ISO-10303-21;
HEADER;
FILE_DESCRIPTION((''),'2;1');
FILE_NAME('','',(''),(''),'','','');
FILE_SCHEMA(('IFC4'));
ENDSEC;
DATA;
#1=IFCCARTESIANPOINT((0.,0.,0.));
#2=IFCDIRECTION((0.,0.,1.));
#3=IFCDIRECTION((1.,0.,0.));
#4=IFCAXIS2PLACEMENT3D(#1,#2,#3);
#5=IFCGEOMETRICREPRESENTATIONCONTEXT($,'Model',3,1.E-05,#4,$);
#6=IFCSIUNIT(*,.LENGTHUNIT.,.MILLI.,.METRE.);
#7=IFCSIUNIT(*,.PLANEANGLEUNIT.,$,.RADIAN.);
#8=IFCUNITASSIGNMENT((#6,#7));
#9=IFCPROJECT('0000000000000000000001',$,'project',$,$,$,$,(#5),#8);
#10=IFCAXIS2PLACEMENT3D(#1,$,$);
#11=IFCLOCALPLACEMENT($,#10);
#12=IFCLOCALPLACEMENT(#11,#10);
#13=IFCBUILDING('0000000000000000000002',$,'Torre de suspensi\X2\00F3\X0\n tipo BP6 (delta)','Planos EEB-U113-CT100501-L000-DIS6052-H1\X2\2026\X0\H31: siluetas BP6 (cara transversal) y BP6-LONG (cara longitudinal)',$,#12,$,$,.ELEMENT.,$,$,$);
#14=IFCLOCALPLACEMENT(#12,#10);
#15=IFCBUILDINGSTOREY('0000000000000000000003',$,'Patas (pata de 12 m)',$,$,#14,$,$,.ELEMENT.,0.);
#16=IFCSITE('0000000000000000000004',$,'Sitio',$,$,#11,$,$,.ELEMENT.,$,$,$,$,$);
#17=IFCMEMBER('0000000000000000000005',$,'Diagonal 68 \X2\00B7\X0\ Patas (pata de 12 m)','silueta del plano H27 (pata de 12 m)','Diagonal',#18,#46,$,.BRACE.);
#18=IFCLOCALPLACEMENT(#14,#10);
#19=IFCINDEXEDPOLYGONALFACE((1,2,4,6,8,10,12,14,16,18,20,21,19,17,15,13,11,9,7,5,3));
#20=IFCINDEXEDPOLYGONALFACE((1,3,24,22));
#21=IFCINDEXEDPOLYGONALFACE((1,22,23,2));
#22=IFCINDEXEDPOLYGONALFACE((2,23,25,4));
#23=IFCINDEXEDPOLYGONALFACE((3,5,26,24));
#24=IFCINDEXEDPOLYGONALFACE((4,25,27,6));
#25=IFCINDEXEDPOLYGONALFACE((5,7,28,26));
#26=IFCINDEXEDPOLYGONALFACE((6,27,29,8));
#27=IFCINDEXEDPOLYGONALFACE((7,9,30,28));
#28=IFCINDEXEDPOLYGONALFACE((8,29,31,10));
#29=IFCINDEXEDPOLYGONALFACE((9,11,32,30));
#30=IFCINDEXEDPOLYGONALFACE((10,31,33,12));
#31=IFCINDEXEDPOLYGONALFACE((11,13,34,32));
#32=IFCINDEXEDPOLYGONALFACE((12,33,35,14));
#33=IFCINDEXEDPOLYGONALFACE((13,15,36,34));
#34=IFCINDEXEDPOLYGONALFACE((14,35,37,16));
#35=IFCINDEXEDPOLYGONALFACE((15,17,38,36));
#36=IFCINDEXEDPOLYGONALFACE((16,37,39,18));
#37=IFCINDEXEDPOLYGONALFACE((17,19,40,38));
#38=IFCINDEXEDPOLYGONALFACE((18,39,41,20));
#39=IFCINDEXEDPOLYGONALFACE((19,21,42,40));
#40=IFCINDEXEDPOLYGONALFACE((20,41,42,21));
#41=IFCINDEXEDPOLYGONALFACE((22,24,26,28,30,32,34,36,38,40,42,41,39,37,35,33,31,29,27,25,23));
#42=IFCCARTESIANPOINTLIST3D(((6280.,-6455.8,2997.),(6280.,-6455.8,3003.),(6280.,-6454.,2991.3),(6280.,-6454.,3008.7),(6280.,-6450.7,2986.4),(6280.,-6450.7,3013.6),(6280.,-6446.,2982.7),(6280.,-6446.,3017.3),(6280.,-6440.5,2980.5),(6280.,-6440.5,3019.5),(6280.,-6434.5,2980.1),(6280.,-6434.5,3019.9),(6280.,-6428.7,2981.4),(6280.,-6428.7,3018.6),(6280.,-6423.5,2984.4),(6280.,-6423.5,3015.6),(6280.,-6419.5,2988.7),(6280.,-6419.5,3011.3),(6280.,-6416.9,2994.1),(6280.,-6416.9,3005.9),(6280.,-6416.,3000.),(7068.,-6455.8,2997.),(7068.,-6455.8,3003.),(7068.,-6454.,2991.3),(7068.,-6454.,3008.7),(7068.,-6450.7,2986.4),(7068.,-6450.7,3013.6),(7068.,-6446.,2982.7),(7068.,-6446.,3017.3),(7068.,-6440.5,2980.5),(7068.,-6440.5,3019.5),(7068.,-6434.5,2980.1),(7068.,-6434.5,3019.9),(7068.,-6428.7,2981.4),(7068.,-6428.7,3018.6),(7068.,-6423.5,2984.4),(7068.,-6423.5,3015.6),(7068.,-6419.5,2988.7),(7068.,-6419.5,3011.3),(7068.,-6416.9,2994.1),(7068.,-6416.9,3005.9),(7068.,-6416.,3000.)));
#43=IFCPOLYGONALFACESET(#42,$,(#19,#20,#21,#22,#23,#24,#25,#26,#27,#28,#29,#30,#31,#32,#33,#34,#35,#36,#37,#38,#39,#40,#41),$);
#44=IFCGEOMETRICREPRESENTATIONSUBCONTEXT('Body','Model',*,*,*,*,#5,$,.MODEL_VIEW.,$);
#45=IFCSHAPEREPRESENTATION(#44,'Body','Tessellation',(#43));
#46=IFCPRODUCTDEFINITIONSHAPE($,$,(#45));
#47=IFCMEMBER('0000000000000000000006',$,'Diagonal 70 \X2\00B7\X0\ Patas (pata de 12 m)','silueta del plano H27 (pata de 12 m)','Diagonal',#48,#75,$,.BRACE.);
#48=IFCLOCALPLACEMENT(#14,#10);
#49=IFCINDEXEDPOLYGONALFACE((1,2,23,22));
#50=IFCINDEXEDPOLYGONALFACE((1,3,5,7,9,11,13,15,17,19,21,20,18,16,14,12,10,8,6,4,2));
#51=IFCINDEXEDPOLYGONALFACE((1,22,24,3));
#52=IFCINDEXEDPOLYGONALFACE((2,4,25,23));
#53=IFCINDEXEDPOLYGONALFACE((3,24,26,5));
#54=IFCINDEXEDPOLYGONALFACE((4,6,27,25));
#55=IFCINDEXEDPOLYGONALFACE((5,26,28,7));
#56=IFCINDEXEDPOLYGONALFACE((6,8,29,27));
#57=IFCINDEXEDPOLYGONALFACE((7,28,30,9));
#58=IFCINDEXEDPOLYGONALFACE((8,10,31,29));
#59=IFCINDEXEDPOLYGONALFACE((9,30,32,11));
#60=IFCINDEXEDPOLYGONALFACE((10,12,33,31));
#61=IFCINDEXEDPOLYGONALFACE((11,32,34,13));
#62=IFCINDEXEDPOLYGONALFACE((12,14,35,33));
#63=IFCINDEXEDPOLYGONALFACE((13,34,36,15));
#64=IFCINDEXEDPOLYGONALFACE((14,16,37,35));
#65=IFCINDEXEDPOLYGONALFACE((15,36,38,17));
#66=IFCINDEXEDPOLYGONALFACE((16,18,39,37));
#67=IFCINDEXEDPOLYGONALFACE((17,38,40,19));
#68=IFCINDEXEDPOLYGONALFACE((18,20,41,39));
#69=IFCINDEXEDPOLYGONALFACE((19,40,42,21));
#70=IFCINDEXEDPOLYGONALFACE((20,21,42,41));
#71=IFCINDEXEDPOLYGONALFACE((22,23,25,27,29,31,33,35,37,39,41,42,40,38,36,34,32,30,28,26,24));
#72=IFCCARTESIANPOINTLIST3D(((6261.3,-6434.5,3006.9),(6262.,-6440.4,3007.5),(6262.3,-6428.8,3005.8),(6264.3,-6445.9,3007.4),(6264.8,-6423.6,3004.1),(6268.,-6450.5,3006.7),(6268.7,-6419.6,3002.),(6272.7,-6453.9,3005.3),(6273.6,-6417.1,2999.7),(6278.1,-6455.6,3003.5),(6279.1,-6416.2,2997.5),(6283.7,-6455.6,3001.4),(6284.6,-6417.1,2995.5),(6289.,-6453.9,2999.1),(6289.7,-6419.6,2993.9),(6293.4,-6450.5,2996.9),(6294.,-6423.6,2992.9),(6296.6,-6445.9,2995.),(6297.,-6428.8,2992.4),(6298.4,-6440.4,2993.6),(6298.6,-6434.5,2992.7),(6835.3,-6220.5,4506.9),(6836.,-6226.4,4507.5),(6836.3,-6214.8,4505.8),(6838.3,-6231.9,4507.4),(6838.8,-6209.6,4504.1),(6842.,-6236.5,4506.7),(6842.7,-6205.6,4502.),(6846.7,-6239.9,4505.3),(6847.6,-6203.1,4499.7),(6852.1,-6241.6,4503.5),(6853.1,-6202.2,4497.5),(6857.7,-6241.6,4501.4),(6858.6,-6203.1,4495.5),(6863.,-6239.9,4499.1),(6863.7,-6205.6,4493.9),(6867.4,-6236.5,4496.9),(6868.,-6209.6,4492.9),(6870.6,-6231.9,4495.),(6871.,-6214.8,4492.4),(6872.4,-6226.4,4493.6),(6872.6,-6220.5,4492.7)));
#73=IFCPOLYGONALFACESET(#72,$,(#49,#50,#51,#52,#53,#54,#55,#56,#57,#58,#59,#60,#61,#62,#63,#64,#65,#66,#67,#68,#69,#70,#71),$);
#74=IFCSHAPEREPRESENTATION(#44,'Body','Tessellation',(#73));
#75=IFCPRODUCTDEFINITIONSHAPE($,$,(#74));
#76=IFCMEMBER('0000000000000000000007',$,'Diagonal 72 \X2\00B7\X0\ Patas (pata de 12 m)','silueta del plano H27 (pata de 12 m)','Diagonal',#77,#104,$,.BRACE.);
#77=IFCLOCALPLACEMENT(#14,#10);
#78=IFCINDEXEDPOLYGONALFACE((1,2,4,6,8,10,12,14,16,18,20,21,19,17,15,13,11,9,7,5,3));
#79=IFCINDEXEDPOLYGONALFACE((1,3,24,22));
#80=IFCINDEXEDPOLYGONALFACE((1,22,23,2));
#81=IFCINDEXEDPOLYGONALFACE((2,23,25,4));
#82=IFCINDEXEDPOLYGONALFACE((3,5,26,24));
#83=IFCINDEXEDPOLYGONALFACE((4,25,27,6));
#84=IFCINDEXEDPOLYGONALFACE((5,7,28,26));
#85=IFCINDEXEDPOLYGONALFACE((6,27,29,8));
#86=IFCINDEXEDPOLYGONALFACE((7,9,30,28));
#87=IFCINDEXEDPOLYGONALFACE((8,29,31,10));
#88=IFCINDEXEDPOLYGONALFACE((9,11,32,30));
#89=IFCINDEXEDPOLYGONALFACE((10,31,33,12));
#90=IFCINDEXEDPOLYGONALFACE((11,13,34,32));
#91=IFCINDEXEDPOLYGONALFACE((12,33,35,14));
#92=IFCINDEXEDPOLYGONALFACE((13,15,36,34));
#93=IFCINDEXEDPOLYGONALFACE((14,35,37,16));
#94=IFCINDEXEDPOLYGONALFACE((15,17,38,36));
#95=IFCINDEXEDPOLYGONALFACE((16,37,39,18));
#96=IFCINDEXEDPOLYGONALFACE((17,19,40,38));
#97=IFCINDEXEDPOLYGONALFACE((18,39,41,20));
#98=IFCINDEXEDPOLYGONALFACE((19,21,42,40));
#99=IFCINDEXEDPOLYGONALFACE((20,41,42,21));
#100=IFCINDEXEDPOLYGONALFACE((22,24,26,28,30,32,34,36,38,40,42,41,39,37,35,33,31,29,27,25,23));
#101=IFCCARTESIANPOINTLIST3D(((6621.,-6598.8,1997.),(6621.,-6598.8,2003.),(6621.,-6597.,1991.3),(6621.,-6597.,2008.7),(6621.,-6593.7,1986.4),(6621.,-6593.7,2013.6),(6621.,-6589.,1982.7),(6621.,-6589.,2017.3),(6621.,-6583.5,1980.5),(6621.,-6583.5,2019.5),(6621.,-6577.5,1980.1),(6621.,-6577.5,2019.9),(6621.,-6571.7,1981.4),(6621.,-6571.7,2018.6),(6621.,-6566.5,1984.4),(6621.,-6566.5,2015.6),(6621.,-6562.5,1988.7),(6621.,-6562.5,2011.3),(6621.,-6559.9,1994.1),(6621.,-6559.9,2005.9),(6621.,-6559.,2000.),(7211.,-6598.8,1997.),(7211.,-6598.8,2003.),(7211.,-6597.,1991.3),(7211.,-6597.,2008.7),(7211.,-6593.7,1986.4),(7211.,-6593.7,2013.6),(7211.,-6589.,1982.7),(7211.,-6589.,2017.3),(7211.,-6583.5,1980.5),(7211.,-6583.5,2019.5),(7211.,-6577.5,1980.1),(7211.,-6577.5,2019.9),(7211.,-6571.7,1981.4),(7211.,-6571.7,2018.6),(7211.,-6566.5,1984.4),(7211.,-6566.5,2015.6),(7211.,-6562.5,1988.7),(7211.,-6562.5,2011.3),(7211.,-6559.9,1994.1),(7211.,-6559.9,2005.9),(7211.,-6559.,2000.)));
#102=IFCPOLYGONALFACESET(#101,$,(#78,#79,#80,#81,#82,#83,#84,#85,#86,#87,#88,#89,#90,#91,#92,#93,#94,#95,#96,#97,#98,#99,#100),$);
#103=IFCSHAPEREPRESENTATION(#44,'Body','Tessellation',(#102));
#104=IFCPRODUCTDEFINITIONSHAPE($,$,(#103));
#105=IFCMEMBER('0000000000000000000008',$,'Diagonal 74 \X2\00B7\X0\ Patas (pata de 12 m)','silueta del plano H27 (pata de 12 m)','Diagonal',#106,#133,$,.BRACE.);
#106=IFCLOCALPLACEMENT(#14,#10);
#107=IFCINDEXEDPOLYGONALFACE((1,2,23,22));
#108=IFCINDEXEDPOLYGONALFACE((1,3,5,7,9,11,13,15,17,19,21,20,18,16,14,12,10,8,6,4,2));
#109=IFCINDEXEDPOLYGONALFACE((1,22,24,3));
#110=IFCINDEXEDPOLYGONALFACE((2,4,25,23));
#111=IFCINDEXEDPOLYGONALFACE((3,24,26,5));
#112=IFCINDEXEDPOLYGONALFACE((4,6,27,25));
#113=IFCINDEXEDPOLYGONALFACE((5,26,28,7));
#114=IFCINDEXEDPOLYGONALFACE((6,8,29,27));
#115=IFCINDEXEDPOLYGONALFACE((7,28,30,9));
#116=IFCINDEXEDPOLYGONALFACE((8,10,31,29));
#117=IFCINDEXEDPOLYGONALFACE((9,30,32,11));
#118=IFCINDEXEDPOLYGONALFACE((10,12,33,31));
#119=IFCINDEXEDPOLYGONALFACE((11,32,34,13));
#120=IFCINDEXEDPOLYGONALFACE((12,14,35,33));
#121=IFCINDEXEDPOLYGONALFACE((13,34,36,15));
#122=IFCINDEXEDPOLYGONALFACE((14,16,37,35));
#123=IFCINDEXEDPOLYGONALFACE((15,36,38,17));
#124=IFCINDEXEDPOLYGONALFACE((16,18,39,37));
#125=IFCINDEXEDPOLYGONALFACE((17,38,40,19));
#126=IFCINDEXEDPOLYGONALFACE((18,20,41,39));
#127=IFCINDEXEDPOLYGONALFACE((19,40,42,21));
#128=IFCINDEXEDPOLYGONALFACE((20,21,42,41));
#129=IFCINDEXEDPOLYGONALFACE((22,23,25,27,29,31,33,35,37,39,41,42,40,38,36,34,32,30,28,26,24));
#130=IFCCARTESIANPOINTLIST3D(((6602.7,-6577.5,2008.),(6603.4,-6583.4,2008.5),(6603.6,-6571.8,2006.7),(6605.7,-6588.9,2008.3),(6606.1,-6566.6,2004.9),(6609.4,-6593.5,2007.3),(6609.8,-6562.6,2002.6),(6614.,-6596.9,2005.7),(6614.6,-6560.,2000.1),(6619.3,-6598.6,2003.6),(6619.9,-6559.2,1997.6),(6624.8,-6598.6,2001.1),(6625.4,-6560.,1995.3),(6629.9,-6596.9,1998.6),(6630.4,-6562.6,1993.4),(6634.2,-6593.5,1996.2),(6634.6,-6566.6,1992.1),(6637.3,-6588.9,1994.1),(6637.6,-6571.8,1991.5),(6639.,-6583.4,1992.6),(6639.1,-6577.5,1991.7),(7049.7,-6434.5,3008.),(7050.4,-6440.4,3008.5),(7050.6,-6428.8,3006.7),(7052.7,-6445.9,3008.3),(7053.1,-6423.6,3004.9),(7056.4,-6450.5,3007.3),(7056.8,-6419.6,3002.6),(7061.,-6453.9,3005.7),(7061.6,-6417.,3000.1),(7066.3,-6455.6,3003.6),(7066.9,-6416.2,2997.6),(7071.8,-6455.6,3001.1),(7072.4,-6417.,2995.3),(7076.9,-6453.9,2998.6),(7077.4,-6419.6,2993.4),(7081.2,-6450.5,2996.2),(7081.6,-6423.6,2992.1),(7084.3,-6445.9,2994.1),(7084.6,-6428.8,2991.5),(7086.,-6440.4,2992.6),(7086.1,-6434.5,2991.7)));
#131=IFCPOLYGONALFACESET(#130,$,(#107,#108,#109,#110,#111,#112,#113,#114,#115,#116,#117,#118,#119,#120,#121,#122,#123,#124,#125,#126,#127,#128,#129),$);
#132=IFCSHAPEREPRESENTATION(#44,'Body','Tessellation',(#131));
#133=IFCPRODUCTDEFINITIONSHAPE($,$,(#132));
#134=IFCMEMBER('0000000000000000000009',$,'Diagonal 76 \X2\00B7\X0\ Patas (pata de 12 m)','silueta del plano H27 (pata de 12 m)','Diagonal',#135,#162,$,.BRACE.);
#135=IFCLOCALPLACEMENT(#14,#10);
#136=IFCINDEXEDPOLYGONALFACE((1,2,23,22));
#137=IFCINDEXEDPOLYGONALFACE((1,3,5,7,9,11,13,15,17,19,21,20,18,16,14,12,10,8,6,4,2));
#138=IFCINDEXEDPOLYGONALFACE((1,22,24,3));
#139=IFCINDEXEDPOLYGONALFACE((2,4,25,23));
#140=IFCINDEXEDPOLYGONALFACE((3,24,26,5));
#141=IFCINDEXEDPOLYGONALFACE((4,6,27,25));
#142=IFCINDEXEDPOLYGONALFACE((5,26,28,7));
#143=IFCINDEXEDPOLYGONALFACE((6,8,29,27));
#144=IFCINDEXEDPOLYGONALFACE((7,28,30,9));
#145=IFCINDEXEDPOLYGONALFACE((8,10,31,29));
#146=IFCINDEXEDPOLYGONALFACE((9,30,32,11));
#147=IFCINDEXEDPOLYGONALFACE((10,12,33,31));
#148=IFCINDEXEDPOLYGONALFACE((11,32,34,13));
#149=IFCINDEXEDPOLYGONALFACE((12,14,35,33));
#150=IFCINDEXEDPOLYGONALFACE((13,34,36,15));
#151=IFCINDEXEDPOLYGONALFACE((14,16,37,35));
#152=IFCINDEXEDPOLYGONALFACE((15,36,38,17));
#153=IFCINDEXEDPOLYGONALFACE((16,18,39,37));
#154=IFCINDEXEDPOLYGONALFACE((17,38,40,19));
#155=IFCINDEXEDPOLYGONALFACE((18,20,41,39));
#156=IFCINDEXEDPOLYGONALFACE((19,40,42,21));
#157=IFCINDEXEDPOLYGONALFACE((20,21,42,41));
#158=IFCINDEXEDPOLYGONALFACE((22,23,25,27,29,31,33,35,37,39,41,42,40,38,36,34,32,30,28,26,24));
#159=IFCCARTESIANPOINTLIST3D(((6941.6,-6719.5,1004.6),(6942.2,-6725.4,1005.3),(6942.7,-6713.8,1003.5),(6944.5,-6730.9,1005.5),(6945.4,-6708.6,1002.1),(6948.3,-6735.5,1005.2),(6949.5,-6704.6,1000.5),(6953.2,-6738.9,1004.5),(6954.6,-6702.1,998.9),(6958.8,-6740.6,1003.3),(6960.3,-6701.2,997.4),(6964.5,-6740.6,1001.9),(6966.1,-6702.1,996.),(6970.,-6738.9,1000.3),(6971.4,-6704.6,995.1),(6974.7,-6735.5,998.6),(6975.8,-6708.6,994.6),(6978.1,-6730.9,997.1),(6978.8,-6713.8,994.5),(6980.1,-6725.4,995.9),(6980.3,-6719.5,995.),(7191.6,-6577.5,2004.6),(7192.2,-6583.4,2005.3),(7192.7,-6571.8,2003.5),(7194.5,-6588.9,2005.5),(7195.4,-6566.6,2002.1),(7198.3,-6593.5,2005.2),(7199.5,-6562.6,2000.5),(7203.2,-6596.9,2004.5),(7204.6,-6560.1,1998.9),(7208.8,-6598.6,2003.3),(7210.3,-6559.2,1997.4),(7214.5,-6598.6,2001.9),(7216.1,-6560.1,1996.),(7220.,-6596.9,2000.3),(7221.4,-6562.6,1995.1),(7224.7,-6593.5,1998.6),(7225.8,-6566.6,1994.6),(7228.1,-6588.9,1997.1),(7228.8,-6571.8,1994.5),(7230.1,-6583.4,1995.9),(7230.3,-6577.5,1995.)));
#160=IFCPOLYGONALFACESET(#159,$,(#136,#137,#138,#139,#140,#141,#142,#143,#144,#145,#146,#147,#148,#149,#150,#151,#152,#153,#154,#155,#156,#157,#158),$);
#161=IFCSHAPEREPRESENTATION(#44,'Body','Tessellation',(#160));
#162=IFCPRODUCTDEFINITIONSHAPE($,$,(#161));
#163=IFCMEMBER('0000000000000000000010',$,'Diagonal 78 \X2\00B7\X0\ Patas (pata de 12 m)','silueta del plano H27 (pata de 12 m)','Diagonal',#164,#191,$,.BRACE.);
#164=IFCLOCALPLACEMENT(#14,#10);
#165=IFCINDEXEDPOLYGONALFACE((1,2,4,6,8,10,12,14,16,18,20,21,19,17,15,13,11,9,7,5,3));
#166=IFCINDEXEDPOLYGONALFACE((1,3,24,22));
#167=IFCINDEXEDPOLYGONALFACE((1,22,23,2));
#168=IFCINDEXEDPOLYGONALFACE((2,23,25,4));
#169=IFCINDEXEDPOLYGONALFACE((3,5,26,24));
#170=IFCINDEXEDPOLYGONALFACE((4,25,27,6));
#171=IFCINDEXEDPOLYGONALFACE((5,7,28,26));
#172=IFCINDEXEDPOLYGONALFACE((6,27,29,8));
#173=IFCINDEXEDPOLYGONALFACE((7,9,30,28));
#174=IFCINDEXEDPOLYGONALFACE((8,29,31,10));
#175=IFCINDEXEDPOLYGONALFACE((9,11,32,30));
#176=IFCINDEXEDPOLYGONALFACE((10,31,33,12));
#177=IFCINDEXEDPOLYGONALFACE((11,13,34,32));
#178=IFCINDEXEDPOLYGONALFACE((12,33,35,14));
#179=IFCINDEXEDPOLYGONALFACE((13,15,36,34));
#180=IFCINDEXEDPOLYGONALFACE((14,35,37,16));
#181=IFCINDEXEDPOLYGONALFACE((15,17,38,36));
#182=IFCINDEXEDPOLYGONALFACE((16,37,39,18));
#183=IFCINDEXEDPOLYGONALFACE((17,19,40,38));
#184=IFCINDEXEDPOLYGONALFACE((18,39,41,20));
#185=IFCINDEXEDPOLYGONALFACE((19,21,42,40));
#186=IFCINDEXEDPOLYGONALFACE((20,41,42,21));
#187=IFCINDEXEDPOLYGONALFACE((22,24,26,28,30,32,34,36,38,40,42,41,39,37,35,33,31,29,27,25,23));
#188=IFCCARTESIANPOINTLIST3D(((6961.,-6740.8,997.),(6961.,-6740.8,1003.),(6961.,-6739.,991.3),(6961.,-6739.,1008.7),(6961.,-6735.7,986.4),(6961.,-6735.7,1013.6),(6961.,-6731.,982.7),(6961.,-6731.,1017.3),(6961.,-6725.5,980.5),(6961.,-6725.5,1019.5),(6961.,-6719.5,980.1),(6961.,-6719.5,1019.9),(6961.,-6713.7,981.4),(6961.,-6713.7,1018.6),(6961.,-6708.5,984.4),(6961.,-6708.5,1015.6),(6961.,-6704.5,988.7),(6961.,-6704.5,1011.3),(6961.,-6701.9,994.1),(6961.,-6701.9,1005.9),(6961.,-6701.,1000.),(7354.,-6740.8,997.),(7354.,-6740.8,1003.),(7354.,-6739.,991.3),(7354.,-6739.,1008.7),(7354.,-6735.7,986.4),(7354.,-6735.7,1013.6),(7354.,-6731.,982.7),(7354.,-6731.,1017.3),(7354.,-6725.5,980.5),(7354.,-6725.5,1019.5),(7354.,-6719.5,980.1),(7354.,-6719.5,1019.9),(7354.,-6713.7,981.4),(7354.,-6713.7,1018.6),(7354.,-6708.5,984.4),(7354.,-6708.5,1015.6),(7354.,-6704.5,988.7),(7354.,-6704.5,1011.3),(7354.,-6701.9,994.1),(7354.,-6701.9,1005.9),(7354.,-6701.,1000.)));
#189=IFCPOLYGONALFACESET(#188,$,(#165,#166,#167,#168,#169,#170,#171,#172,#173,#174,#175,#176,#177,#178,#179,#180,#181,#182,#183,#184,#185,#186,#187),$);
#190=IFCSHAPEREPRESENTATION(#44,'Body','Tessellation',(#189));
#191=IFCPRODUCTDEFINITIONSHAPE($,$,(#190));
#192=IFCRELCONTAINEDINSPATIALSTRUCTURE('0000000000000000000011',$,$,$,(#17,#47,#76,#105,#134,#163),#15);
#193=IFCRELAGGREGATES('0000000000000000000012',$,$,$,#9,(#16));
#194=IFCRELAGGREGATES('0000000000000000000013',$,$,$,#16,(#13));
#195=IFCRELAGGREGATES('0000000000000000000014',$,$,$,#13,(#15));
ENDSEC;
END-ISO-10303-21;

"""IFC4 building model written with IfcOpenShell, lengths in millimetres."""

from ifc_helpers import new_model, si_unit, frame, origin, origin_with_axes, place, context, subcontext, project, spatial, circle, extrude, element, save


model = new_model("IFC4")

# Units and contexts
model_context = context("Model", 3, precision=1e-05, world=origin_with_axes())
body_context = subcontext(model_context, "Body", "Model", "MODEL_VIEW")
ifc_project = project(units=[si_unit("LENGTHUNIT", "METRE", prefix="MILLI"), si_unit("PLANEANGLEUNIT", "RADIAN")], contexts=[model_context])

# Site, building, storey
site_placement = place(None, origin())
site = spatial("IfcSite", under=ifc_project, at=site_placement, Name="Sitio", CompositionType="ELEMENT")
building_placement = place(site_placement, origin())
building = spatial("IfcBuilding", under=site, at=building_placement, Name="Torre de suspensión tipo BP6 (delta)", Description="Planos EEB-U113-CT100501-L000-DIS6052-H1…H31: siluetas BP6 (cara transversal) y BP6-LONG (cara longitudinal)", CompositionType="ELEMENT")
storey_placement = place(building_placement, origin())
storey = spatial("IfcBuildingStorey", under=building, at=storey_placement, Name="Patas (pata de 12 m)", CompositionType="ELEMENT", Elevation=0.0)

# Members
member_1_placement = place(storey_placement, frame((7068.0, -6436.0, 3000.0), z_axis=(-1.0, 0.0, 0.0), x_axis=(0.0, 1.0, 0.0)))
element("IfcMember", 1, at=member_1_placement, inside=storey, Name="Diagonal 68 · Patas (pata de 12 m)", Description="silueta del plano H27 (pata de 12 m)", ObjectType="Diagonal", PredefinedType="BRACE", context=body_context, shape_type="SweptSolid", body=[
    extrude(circle(Radius=20.0), None, (0.0, 0.0, 1.0), 788.0),
])
member_2_placement = place(storey_placement, frame((6280.0, -6436.0, 3000.0), z_axis=(0.354262, 0.132077, 0.925772), x_axis=(-0.047203, 0.991239, -0.123354)))
element("IfcMember", 2, at=member_2_placement, inside=storey, Name="Diagonal 70 · Patas (pata de 12 m)", Description="silueta del plano H27 (pata de 12 m)", ObjectType="Diagonal", PredefinedType="BRACE", context=body_context, shape_type="SweptSolid", body=[
    extrude(circle(Radius=20.0), None, (0.0, 0.0, 1.0), 1620.3),
])
member_3_placement = place(storey_placement, frame((7211.0, -6579.0, 2000.0), z_axis=(-1.0, 0.0, 0.0), x_axis=(0.0, 1.0, 0.0)))
element("IfcMember", 3, at=member_3_placement, inside=storey, Name="Diagonal 72 · Patas (pata de 12 m)", Description="silueta del plano H27 (pata de 12 m)", ObjectType="Diagonal", PredefinedType="BRACE", context=body_context, shape_type="SweptSolid", body=[
    extrude(circle(Radius=20.0), None, (0.0, 0.0, 1.0), 590.0),
])
member_4_placement = place(storey_placement, frame((6621.0, -6579.0, 2000.0), z_axis=(0.404652, 0.129452, 0.905262), x_axis=(-0.052828, 0.991586, -0.118183)))
element("IfcMember", 4, at=member_4_placement, inside=storey, Name="Diagonal 74 · Patas (pata de 12 m)", Description="silueta del plano H27 (pata de 12 m)", ObjectType="Diagonal", PredefinedType="BRACE", context=body_context, shape_type="SweptSolid", body=[
    extrude(circle(Radius=20.0), None, (0.0, 0.0, 1.0), 1104.7),
])
member_5_placement = place(storey_placement, frame((6961.0, -6721.0, 1000.0), z_axis=(0.240266, 0.136471, 0.961066), x_axis=(-0.033099, 0.990644, -0.132397)))
element("IfcMember", 5, at=member_5_placement, inside=storey, Name="Diagonal 76 · Patas (pata de 12 m)", Description="silueta del plano H27 (pata de 12 m)", ObjectType="Diagonal", PredefinedType="BRACE", context=body_context, shape_type="SweptSolid", body=[
    extrude(circle(Radius=20.0), None, (0.0, 0.0, 1.0), 1040.5),
])
member_6_placement = place(storey_placement, frame((7354.0, -6721.0, 1000.0), z_axis=(-1.0, 0.0, 0.0), x_axis=(0.0, 1.0, 0.0)))
element("IfcMember", 6, at=member_6_placement, inside=storey, Name="Diagonal 78 · Patas (pata de 12 m)", Description="silueta del plano H27 (pata de 12 m)", ObjectType="Diagonal", PredefinedType="BRACE", context=body_context, shape_type="SweptSolid", body=[
    extrude(circle(Radius=20.0), None, (0.0, 0.0, 1.0), 393.0),
])

save(model, "model.ifc")
